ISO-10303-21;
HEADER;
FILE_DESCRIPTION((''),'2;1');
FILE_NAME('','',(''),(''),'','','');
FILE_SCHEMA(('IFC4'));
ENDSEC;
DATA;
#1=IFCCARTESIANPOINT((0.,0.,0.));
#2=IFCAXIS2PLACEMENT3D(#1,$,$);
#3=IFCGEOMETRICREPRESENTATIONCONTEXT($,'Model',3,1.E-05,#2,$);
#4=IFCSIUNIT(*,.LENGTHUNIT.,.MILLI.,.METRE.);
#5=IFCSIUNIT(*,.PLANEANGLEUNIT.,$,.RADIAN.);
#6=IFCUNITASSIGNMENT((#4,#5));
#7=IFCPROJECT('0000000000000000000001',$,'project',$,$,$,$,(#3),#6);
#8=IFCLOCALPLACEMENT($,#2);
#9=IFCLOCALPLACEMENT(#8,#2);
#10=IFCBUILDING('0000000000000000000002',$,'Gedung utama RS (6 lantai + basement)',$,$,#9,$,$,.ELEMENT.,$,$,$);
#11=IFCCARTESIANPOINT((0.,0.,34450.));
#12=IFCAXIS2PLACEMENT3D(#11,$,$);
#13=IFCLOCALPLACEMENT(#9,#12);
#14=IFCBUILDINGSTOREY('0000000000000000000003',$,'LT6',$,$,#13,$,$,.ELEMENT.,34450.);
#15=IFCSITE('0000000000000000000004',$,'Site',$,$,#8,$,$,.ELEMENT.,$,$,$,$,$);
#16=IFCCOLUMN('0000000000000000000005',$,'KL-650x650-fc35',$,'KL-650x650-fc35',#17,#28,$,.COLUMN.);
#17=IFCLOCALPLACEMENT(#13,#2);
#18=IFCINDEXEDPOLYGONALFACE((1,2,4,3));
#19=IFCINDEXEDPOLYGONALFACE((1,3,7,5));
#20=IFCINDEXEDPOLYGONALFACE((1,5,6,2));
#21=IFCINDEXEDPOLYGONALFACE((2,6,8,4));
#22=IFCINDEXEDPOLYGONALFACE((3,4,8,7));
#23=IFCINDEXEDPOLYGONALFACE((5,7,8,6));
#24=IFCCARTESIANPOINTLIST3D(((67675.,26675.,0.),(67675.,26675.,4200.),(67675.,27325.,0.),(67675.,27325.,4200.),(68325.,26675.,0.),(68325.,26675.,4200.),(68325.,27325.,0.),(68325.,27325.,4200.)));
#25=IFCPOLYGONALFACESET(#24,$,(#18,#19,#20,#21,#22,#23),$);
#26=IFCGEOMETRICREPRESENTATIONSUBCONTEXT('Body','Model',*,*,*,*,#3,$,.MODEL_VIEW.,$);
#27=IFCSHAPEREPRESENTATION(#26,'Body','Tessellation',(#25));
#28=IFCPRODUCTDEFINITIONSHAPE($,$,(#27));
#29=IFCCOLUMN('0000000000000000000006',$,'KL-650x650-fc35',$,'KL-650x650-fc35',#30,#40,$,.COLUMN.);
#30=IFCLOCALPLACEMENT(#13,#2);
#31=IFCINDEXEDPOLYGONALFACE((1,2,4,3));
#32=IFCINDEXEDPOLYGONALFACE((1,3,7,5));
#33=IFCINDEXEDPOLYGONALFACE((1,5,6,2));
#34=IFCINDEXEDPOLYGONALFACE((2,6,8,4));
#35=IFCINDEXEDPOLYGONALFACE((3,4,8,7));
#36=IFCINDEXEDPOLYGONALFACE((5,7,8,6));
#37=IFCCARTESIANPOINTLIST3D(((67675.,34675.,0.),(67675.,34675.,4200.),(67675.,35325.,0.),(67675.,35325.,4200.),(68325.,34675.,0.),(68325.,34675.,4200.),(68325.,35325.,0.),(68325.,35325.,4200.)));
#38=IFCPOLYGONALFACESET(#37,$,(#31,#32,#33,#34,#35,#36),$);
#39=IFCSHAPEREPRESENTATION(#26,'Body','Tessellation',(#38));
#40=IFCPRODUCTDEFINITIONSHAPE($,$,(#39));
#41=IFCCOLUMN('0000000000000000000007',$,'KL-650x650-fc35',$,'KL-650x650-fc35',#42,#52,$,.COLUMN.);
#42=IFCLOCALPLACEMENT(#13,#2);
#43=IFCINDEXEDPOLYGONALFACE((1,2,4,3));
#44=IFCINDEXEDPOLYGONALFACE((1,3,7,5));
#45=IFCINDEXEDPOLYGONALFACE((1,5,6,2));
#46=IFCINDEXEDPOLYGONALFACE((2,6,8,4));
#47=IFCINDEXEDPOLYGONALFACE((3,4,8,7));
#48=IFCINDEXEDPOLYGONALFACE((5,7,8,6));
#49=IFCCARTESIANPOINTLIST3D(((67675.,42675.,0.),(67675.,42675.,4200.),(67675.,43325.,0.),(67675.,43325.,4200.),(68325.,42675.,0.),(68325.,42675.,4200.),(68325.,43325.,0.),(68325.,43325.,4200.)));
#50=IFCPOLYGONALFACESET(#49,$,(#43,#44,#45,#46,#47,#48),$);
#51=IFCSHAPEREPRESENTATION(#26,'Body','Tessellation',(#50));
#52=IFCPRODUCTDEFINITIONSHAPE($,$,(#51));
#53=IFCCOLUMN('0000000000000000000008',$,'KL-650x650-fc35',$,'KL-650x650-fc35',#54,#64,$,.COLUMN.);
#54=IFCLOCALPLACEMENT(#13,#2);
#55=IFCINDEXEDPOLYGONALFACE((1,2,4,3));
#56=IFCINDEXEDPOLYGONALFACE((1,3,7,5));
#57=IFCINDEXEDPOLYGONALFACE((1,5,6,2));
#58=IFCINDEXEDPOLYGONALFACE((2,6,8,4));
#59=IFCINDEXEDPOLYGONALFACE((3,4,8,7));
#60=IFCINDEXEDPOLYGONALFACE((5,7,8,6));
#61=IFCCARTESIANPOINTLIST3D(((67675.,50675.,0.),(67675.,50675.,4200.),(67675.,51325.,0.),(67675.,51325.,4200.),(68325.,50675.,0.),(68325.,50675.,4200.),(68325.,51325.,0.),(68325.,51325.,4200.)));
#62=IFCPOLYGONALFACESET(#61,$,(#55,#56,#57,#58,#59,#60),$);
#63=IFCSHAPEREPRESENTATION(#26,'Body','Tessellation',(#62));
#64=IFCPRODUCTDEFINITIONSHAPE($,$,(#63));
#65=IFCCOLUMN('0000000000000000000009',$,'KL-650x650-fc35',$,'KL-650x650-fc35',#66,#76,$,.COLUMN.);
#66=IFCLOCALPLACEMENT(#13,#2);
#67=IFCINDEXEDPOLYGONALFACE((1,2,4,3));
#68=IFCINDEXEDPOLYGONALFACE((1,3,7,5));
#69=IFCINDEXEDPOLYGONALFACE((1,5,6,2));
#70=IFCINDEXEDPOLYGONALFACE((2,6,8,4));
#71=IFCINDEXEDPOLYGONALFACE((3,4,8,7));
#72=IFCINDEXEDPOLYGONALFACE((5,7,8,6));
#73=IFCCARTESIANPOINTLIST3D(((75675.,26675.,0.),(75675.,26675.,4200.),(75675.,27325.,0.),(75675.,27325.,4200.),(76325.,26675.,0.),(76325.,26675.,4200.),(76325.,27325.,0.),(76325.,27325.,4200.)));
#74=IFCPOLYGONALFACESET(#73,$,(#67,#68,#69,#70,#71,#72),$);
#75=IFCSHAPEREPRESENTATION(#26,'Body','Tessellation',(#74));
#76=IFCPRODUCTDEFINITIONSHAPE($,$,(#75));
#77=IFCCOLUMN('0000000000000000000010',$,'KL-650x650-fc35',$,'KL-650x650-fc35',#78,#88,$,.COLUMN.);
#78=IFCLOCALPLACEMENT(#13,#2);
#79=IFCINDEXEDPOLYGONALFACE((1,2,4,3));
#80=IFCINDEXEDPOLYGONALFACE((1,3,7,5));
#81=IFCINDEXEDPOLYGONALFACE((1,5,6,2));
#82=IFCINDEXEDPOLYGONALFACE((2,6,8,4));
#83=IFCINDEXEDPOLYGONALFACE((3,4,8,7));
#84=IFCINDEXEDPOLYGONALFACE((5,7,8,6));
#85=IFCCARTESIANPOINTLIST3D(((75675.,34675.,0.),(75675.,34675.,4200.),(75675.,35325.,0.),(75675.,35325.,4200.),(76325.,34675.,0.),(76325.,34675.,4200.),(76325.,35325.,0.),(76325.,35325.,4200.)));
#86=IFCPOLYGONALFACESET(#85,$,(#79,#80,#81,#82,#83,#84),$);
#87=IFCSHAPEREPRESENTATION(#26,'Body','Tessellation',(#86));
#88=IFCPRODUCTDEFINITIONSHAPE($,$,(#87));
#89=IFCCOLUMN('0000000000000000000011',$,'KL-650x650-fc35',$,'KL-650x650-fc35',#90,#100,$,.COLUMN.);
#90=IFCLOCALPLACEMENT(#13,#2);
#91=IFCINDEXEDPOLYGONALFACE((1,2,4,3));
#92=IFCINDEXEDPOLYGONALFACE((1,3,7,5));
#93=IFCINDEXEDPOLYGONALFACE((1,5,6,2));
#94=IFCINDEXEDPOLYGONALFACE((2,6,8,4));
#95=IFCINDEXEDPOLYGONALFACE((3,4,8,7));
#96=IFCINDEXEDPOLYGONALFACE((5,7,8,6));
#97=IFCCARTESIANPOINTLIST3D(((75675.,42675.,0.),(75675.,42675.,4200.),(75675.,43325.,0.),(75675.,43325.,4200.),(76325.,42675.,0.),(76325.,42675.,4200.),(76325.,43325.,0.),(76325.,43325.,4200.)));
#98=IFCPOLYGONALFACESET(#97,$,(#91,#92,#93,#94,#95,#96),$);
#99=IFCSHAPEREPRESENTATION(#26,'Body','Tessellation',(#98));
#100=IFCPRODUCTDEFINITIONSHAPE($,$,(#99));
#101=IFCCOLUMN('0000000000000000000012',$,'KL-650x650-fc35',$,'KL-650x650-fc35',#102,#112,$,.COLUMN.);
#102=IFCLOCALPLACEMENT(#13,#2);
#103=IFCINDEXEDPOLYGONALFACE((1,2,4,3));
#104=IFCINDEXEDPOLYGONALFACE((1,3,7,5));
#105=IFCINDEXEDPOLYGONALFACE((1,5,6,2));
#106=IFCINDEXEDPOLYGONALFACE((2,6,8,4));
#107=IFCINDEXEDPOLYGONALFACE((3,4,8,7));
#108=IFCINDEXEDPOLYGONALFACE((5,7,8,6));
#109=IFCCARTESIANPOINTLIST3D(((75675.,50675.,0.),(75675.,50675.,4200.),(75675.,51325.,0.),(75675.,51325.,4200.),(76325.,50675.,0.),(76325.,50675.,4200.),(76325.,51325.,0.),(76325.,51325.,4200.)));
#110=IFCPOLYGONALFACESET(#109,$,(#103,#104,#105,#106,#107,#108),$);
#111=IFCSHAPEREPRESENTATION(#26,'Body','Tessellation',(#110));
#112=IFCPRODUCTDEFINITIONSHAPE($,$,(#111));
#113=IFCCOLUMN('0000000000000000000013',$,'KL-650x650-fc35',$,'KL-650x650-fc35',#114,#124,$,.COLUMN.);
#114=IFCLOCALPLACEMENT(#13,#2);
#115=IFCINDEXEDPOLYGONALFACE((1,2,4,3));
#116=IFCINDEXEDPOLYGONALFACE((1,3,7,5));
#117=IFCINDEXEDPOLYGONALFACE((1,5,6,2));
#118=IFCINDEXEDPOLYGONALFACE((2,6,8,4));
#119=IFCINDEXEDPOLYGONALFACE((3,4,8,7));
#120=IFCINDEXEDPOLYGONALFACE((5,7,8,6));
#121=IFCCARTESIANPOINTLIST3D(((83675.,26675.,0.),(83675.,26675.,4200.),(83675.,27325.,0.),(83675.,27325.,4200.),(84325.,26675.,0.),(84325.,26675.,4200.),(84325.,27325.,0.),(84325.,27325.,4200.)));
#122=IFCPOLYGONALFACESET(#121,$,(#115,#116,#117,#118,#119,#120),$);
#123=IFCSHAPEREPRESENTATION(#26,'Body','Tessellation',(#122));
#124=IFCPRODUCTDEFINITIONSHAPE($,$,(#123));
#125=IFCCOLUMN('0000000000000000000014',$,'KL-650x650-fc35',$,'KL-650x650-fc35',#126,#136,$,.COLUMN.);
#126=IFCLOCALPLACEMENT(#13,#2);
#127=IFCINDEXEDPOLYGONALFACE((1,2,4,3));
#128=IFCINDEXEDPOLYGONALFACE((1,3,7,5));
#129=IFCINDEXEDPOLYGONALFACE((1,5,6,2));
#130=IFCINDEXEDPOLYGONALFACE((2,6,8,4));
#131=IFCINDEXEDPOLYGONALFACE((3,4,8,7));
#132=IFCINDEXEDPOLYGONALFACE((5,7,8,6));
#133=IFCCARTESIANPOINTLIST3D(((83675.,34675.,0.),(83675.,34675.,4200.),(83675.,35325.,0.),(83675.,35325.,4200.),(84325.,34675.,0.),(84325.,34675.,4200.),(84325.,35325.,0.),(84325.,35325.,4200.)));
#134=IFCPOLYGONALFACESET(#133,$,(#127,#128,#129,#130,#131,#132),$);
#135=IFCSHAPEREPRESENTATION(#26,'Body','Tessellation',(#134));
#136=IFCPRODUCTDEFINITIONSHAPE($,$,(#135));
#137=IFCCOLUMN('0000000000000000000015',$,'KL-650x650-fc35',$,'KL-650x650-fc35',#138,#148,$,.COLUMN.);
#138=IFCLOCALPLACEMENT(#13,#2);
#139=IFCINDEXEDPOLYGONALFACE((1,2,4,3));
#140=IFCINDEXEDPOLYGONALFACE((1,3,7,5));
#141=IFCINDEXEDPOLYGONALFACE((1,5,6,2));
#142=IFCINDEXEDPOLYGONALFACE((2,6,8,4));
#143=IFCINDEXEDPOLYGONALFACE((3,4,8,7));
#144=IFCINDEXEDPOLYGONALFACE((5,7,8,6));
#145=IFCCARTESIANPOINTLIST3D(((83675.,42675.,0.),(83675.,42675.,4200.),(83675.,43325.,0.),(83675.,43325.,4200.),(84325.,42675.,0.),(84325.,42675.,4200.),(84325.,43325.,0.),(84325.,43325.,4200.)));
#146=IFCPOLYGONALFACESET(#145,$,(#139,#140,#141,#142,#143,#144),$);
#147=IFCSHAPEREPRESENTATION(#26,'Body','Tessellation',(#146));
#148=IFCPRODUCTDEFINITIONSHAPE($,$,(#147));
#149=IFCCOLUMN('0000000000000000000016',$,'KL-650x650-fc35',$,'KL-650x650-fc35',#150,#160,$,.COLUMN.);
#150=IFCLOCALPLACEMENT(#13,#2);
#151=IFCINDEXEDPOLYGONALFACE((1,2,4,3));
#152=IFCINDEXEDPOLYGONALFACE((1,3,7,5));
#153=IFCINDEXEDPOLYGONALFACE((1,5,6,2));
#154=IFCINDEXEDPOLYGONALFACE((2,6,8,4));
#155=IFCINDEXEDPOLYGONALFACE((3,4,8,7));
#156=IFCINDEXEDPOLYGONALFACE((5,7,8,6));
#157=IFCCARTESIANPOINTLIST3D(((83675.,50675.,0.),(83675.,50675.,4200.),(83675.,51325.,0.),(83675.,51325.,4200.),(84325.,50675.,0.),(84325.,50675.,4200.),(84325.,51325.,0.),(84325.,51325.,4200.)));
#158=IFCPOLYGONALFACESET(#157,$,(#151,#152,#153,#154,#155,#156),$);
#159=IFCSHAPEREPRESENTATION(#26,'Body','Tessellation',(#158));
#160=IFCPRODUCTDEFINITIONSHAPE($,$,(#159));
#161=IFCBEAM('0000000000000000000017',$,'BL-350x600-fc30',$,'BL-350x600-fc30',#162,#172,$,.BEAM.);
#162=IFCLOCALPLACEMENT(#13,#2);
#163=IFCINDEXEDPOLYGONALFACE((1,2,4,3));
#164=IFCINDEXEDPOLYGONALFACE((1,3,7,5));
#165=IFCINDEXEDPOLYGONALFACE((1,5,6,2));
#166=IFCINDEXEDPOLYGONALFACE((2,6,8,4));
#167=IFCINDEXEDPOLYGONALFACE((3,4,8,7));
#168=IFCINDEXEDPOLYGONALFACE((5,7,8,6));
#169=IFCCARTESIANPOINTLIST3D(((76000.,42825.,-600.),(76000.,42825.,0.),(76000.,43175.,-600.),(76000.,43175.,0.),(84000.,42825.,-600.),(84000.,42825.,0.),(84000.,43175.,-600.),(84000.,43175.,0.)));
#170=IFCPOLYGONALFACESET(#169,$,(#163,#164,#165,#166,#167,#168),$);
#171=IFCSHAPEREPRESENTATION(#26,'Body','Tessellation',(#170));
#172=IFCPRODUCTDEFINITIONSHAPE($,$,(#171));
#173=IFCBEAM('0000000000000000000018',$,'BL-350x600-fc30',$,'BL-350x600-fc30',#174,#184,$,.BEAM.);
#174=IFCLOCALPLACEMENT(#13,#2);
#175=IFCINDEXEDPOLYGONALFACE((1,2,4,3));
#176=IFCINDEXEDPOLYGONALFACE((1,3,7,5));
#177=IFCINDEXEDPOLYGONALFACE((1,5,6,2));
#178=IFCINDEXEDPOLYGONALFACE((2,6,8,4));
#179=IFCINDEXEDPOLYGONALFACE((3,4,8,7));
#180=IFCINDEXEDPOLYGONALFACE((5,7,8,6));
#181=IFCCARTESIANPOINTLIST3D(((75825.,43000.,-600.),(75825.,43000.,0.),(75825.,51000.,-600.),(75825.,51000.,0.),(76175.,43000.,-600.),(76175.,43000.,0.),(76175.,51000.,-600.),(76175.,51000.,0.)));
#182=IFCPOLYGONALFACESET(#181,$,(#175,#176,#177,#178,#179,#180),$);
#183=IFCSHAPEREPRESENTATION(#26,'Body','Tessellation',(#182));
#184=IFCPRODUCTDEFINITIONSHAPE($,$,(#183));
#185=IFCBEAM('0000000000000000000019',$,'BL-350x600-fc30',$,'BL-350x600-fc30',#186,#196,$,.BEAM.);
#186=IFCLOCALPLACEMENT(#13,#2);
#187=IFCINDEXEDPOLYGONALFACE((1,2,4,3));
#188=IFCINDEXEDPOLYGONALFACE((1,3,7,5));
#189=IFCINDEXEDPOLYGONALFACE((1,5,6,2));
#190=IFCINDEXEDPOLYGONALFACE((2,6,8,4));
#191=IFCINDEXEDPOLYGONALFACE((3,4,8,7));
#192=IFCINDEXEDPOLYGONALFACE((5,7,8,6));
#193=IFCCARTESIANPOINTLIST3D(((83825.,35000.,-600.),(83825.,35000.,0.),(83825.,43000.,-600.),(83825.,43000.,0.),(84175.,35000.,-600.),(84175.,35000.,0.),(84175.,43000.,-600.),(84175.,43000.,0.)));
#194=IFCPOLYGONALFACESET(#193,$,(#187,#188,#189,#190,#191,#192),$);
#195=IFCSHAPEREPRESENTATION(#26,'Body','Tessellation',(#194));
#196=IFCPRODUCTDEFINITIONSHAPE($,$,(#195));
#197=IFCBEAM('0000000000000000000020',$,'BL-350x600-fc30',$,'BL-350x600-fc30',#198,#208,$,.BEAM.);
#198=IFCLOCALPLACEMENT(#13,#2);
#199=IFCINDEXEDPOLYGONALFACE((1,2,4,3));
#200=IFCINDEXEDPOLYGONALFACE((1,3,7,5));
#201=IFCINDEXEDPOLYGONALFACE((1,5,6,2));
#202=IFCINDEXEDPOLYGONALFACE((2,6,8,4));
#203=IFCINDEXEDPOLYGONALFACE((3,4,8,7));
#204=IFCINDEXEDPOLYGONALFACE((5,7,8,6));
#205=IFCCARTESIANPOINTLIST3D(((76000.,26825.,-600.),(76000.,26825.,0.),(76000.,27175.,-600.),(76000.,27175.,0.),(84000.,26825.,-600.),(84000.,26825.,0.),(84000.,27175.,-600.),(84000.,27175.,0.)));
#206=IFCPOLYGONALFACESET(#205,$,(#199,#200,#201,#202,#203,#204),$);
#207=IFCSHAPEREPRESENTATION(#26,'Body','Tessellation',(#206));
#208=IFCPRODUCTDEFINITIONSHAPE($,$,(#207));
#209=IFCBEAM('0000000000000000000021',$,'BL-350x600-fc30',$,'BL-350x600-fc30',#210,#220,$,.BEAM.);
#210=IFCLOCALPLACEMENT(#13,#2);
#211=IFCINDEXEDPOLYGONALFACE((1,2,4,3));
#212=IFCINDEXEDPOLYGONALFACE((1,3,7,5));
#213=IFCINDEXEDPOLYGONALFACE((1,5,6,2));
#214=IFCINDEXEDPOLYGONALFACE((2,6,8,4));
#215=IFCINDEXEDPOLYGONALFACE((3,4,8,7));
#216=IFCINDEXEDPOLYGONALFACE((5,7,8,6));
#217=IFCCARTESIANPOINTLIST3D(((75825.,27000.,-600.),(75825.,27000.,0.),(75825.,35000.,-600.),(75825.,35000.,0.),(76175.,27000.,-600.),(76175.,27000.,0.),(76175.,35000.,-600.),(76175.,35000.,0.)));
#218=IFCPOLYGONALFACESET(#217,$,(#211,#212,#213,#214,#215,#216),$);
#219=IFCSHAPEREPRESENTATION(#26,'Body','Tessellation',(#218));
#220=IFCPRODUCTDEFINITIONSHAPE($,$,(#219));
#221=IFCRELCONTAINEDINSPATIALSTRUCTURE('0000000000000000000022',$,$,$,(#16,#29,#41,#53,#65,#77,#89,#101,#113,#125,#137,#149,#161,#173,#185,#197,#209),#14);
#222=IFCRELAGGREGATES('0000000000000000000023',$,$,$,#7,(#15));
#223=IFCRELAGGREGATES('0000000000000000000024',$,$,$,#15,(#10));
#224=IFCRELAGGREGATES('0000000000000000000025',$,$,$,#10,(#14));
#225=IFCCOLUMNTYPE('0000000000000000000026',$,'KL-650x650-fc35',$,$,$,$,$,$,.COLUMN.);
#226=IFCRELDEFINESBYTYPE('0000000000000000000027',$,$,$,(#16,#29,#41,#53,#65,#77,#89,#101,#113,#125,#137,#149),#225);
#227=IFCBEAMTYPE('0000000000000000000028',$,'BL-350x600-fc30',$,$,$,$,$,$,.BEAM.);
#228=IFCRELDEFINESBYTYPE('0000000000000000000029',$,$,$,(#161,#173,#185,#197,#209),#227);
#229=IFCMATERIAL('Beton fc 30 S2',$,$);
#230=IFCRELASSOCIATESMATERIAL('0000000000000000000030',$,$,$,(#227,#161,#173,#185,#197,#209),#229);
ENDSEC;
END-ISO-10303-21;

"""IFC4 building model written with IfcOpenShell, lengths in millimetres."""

from ifc_helpers import new_model, si_unit, frame, origin, origin_2d, place, context, subcontext, project, spatial, rectangle, extrude, material, material_profile, profile_set, profile_usage, type_object, element, save


model = new_model("IFC4")

# Units and contexts
model_context = context("Model", 3, precision=1e-05, world=origin())
body_context = subcontext(model_context, "Body", "Model", "MODEL_VIEW")
ifc_project = project(units=[si_unit("LENGTHUNIT", "METRE", prefix="MILLI"), si_unit("PLANEANGLEUNIT", "RADIAN")], contexts=[model_context])

# Site, building, storey
site_placement = place(None, origin())
site = spatial("IfcSite", under=ifc_project, at=site_placement, Name="Site", CompositionType="ELEMENT")
building_placement = place(site_placement, origin())
building = spatial("IfcBuilding", under=site, at=building_placement, Name="Gedung utama RS (6 lantai + basement)", CompositionType="ELEMENT")
storey_placement = place(building_placement, frame((0.0, 0.0, 34450.0)))
storey = spatial("IfcBuildingStorey", under=building, at=storey_placement, Name="LT6", CompositionType="ELEMENT", Elevation=34450.0)

# Columns
ifc_material_profile_1 = material_profile(None, rectangle(XDim=650.0, YDim=650.0, at=origin_2d()), Name="KL-650x650-fc35")
ifc_profile_set_1 = profile_set([ifc_material_profile_1], Name="KL-650x650-fc35")
ifc_profile_usage_1 = profile_usage(ifc_profile_set_1, cardinal=5)
column_type = type_object("IfcColumnType", Name="KL-650x650-fc35", PredefinedType="COLUMN", material=ifc_profile_set_1)
for number, where, z_axis, x_axis, name in (
    (1, (68000.0, 27000.0, 0.0), (0.0, 0.0, 1.0), (1.0, 0.0, 0.0), "KL-650x650-fc35"),
    (2, (68000.0, 35000.0, 0.0), (0.0, 0.0, 1.0), (1.0, 0.0, 0.0), "KL-650x650-fc35"),
    (3, (68000.0, 43000.0, 0.0), (0.0, 0.0, 1.0), (1.0, 0.0, 0.0), "KL-650x650-fc35"),
    (4, (68000.0, 51000.0, 0.0), (0.0, 0.0, 1.0), (1.0, 0.0, 0.0), "KL-650x650-fc35"),
    (5, (76000.0, 27000.0, 0.0), (0.0, 0.0, 1.0), (1.0, 0.0, 0.0), "KL-650x650-fc35"),
    (6, (76000.0, 35000.0, 0.0), (0.0, 0.0, 1.0), (1.0, 0.0, 0.0), "KL-650x650-fc35"),
    (7, (76000.0, 43000.0, 0.0), (0.0, 0.0, 1.0), (1.0, 0.0, 0.0), "KL-650x650-fc35"),
    (8, (76000.0, 51000.0, 0.0), (0.0, 0.0, 1.0), (1.0, 0.0, 0.0), "KL-650x650-fc35"),
    (9, (84000.0, 27000.0, 0.0), (0.0, 0.0, 1.0), (1.0, 0.0, 0.0), "KL-650x650-fc35"),
    (10, (84000.0, 35000.0, 0.0), (0.0, 0.0, 1.0), (1.0, 0.0, 0.0), "KL-650x650-fc35"),
    (11, (84000.0, 43000.0, 0.0), (0.0, 0.0, 1.0), (1.0, 0.0, 0.0), "KL-650x650-fc35"),
    (12, (84000.0, 51000.0, 0.0), (0.0, 0.0, 1.0), (1.0, 0.0, 0.0), "KL-650x650-fc35"),
):
    element("IfcColumn", number, at=place(storey_placement, frame(where, z_axis=z_axis, x_axis=x_axis)), inside=storey, type_object=column_type, material=ifc_profile_usage_1, Name=name, ObjectType="KL-650x650-fc35", PredefinedType="COLUMN", context=body_context, shape_type="SweptSolid", body=[
        extrude(rectangle(XDim=650.0, YDim=650.0, at=origin_2d()), origin(), (0.0, 0.0, 1.0), 4200.0),
    ])

# Beams
ifc_material_1 = material(Name="Beton fc 30 S2")
ifc_material_profile_2 = material_profile(ifc_material_1, rectangle(XDim=350.0, YDim=600.0, at=origin_2d()), Name="BL-350x600-fc30")
ifc_profile_set_2 = profile_set([ifc_material_profile_2], Name="BL-350x600-fc30")
ifc_profile_usage_2 = profile_usage(ifc_profile_set_2, cardinal=8)
beam_type = type_object("IfcBeamType", Name="BL-350x600-fc30", PredefinedType="BEAM", material=ifc_profile_set_2)
beam_1_placement = place(storey_placement, frame((76000.0, 43000.0, -300.0)))
element("IfcBeam", 13, at=beam_1_placement, inside=storey, type_object=beam_type, material=ifc_profile_usage_2, Name="BL-350x600-fc30", ObjectType="BL-350x600-fc30", PredefinedType="BEAM", context=body_context, shape_type="SweptSolid", body=[
    extrude(rectangle(XDim=350.0, YDim=600.0, at=origin_2d()), frame((0.0, 0.0, 0.0), z_axis=(1.0, 0.0, 0.0), x_axis=(0.0, 1.0, 0.0)), (0.0, 0.0, 1.0), 8000.0),
])
for number, where, name in (
    (14, (76000.0, 43000.0, -300.0), "BL-350x600-fc30"),
    (15, (84000.0, 35000.0, -300.0), "BL-350x600-fc30"),
):
    element("IfcBeam", number, at=place(storey_placement, frame(where)), inside=storey, type_object=beam_type, material=ifc_profile_usage_2, Name=name, ObjectType="BL-350x600-fc30", PredefinedType="BEAM", context=body_context, shape_type="SweptSolid", body=[
        extrude(rectangle(XDim=350.0, YDim=600.0, at=origin_2d()), frame((0.0, 0.0, 0.0), z_axis=(0.0, 1.0, 0.0), x_axis=(-1.0, 0.0, 0.0)), (0.0, 0.0, 1.0), 8000.0),
    ])
beam_2_placement = place(storey_placement, frame((76000.0, 27000.0, -300.0)))
element("IfcBeam", 16, at=beam_2_placement, inside=storey, type_object=beam_type, material=ifc_profile_usage_2, Name="BL-350x600-fc30", ObjectType="BL-350x600-fc30", PredefinedType="BEAM", context=body_context, shape_type="SweptSolid", body=[
    extrude(rectangle(XDim=350.0, YDim=600.0, at=origin_2d()), frame((0.0, 0.0, 0.0), z_axis=(1.0, 0.0, 0.0), x_axis=(0.0, 1.0, 0.0)), (0.0, 0.0, 1.0), 8000.0),
])
beam_3_placement = place(storey_placement, frame((76000.0, 27000.0, -300.0)))
element("IfcBeam", 17, at=beam_3_placement, inside=storey, type_object=beam_type, material=ifc_profile_usage_2, Name="BL-350x600-fc30", ObjectType="BL-350x600-fc30", PredefinedType="BEAM", context=body_context, shape_type="SweptSolid", body=[
    extrude(rectangle(XDim=350.0, YDim=600.0, at=origin_2d()), frame((0.0, 0.0, 0.0), z_axis=(0.0, 1.0, 0.0), x_axis=(-1.0, 0.0, 0.0)), (0.0, 0.0, 1.0), 8000.0),
])

save(model, "model.ifc")
